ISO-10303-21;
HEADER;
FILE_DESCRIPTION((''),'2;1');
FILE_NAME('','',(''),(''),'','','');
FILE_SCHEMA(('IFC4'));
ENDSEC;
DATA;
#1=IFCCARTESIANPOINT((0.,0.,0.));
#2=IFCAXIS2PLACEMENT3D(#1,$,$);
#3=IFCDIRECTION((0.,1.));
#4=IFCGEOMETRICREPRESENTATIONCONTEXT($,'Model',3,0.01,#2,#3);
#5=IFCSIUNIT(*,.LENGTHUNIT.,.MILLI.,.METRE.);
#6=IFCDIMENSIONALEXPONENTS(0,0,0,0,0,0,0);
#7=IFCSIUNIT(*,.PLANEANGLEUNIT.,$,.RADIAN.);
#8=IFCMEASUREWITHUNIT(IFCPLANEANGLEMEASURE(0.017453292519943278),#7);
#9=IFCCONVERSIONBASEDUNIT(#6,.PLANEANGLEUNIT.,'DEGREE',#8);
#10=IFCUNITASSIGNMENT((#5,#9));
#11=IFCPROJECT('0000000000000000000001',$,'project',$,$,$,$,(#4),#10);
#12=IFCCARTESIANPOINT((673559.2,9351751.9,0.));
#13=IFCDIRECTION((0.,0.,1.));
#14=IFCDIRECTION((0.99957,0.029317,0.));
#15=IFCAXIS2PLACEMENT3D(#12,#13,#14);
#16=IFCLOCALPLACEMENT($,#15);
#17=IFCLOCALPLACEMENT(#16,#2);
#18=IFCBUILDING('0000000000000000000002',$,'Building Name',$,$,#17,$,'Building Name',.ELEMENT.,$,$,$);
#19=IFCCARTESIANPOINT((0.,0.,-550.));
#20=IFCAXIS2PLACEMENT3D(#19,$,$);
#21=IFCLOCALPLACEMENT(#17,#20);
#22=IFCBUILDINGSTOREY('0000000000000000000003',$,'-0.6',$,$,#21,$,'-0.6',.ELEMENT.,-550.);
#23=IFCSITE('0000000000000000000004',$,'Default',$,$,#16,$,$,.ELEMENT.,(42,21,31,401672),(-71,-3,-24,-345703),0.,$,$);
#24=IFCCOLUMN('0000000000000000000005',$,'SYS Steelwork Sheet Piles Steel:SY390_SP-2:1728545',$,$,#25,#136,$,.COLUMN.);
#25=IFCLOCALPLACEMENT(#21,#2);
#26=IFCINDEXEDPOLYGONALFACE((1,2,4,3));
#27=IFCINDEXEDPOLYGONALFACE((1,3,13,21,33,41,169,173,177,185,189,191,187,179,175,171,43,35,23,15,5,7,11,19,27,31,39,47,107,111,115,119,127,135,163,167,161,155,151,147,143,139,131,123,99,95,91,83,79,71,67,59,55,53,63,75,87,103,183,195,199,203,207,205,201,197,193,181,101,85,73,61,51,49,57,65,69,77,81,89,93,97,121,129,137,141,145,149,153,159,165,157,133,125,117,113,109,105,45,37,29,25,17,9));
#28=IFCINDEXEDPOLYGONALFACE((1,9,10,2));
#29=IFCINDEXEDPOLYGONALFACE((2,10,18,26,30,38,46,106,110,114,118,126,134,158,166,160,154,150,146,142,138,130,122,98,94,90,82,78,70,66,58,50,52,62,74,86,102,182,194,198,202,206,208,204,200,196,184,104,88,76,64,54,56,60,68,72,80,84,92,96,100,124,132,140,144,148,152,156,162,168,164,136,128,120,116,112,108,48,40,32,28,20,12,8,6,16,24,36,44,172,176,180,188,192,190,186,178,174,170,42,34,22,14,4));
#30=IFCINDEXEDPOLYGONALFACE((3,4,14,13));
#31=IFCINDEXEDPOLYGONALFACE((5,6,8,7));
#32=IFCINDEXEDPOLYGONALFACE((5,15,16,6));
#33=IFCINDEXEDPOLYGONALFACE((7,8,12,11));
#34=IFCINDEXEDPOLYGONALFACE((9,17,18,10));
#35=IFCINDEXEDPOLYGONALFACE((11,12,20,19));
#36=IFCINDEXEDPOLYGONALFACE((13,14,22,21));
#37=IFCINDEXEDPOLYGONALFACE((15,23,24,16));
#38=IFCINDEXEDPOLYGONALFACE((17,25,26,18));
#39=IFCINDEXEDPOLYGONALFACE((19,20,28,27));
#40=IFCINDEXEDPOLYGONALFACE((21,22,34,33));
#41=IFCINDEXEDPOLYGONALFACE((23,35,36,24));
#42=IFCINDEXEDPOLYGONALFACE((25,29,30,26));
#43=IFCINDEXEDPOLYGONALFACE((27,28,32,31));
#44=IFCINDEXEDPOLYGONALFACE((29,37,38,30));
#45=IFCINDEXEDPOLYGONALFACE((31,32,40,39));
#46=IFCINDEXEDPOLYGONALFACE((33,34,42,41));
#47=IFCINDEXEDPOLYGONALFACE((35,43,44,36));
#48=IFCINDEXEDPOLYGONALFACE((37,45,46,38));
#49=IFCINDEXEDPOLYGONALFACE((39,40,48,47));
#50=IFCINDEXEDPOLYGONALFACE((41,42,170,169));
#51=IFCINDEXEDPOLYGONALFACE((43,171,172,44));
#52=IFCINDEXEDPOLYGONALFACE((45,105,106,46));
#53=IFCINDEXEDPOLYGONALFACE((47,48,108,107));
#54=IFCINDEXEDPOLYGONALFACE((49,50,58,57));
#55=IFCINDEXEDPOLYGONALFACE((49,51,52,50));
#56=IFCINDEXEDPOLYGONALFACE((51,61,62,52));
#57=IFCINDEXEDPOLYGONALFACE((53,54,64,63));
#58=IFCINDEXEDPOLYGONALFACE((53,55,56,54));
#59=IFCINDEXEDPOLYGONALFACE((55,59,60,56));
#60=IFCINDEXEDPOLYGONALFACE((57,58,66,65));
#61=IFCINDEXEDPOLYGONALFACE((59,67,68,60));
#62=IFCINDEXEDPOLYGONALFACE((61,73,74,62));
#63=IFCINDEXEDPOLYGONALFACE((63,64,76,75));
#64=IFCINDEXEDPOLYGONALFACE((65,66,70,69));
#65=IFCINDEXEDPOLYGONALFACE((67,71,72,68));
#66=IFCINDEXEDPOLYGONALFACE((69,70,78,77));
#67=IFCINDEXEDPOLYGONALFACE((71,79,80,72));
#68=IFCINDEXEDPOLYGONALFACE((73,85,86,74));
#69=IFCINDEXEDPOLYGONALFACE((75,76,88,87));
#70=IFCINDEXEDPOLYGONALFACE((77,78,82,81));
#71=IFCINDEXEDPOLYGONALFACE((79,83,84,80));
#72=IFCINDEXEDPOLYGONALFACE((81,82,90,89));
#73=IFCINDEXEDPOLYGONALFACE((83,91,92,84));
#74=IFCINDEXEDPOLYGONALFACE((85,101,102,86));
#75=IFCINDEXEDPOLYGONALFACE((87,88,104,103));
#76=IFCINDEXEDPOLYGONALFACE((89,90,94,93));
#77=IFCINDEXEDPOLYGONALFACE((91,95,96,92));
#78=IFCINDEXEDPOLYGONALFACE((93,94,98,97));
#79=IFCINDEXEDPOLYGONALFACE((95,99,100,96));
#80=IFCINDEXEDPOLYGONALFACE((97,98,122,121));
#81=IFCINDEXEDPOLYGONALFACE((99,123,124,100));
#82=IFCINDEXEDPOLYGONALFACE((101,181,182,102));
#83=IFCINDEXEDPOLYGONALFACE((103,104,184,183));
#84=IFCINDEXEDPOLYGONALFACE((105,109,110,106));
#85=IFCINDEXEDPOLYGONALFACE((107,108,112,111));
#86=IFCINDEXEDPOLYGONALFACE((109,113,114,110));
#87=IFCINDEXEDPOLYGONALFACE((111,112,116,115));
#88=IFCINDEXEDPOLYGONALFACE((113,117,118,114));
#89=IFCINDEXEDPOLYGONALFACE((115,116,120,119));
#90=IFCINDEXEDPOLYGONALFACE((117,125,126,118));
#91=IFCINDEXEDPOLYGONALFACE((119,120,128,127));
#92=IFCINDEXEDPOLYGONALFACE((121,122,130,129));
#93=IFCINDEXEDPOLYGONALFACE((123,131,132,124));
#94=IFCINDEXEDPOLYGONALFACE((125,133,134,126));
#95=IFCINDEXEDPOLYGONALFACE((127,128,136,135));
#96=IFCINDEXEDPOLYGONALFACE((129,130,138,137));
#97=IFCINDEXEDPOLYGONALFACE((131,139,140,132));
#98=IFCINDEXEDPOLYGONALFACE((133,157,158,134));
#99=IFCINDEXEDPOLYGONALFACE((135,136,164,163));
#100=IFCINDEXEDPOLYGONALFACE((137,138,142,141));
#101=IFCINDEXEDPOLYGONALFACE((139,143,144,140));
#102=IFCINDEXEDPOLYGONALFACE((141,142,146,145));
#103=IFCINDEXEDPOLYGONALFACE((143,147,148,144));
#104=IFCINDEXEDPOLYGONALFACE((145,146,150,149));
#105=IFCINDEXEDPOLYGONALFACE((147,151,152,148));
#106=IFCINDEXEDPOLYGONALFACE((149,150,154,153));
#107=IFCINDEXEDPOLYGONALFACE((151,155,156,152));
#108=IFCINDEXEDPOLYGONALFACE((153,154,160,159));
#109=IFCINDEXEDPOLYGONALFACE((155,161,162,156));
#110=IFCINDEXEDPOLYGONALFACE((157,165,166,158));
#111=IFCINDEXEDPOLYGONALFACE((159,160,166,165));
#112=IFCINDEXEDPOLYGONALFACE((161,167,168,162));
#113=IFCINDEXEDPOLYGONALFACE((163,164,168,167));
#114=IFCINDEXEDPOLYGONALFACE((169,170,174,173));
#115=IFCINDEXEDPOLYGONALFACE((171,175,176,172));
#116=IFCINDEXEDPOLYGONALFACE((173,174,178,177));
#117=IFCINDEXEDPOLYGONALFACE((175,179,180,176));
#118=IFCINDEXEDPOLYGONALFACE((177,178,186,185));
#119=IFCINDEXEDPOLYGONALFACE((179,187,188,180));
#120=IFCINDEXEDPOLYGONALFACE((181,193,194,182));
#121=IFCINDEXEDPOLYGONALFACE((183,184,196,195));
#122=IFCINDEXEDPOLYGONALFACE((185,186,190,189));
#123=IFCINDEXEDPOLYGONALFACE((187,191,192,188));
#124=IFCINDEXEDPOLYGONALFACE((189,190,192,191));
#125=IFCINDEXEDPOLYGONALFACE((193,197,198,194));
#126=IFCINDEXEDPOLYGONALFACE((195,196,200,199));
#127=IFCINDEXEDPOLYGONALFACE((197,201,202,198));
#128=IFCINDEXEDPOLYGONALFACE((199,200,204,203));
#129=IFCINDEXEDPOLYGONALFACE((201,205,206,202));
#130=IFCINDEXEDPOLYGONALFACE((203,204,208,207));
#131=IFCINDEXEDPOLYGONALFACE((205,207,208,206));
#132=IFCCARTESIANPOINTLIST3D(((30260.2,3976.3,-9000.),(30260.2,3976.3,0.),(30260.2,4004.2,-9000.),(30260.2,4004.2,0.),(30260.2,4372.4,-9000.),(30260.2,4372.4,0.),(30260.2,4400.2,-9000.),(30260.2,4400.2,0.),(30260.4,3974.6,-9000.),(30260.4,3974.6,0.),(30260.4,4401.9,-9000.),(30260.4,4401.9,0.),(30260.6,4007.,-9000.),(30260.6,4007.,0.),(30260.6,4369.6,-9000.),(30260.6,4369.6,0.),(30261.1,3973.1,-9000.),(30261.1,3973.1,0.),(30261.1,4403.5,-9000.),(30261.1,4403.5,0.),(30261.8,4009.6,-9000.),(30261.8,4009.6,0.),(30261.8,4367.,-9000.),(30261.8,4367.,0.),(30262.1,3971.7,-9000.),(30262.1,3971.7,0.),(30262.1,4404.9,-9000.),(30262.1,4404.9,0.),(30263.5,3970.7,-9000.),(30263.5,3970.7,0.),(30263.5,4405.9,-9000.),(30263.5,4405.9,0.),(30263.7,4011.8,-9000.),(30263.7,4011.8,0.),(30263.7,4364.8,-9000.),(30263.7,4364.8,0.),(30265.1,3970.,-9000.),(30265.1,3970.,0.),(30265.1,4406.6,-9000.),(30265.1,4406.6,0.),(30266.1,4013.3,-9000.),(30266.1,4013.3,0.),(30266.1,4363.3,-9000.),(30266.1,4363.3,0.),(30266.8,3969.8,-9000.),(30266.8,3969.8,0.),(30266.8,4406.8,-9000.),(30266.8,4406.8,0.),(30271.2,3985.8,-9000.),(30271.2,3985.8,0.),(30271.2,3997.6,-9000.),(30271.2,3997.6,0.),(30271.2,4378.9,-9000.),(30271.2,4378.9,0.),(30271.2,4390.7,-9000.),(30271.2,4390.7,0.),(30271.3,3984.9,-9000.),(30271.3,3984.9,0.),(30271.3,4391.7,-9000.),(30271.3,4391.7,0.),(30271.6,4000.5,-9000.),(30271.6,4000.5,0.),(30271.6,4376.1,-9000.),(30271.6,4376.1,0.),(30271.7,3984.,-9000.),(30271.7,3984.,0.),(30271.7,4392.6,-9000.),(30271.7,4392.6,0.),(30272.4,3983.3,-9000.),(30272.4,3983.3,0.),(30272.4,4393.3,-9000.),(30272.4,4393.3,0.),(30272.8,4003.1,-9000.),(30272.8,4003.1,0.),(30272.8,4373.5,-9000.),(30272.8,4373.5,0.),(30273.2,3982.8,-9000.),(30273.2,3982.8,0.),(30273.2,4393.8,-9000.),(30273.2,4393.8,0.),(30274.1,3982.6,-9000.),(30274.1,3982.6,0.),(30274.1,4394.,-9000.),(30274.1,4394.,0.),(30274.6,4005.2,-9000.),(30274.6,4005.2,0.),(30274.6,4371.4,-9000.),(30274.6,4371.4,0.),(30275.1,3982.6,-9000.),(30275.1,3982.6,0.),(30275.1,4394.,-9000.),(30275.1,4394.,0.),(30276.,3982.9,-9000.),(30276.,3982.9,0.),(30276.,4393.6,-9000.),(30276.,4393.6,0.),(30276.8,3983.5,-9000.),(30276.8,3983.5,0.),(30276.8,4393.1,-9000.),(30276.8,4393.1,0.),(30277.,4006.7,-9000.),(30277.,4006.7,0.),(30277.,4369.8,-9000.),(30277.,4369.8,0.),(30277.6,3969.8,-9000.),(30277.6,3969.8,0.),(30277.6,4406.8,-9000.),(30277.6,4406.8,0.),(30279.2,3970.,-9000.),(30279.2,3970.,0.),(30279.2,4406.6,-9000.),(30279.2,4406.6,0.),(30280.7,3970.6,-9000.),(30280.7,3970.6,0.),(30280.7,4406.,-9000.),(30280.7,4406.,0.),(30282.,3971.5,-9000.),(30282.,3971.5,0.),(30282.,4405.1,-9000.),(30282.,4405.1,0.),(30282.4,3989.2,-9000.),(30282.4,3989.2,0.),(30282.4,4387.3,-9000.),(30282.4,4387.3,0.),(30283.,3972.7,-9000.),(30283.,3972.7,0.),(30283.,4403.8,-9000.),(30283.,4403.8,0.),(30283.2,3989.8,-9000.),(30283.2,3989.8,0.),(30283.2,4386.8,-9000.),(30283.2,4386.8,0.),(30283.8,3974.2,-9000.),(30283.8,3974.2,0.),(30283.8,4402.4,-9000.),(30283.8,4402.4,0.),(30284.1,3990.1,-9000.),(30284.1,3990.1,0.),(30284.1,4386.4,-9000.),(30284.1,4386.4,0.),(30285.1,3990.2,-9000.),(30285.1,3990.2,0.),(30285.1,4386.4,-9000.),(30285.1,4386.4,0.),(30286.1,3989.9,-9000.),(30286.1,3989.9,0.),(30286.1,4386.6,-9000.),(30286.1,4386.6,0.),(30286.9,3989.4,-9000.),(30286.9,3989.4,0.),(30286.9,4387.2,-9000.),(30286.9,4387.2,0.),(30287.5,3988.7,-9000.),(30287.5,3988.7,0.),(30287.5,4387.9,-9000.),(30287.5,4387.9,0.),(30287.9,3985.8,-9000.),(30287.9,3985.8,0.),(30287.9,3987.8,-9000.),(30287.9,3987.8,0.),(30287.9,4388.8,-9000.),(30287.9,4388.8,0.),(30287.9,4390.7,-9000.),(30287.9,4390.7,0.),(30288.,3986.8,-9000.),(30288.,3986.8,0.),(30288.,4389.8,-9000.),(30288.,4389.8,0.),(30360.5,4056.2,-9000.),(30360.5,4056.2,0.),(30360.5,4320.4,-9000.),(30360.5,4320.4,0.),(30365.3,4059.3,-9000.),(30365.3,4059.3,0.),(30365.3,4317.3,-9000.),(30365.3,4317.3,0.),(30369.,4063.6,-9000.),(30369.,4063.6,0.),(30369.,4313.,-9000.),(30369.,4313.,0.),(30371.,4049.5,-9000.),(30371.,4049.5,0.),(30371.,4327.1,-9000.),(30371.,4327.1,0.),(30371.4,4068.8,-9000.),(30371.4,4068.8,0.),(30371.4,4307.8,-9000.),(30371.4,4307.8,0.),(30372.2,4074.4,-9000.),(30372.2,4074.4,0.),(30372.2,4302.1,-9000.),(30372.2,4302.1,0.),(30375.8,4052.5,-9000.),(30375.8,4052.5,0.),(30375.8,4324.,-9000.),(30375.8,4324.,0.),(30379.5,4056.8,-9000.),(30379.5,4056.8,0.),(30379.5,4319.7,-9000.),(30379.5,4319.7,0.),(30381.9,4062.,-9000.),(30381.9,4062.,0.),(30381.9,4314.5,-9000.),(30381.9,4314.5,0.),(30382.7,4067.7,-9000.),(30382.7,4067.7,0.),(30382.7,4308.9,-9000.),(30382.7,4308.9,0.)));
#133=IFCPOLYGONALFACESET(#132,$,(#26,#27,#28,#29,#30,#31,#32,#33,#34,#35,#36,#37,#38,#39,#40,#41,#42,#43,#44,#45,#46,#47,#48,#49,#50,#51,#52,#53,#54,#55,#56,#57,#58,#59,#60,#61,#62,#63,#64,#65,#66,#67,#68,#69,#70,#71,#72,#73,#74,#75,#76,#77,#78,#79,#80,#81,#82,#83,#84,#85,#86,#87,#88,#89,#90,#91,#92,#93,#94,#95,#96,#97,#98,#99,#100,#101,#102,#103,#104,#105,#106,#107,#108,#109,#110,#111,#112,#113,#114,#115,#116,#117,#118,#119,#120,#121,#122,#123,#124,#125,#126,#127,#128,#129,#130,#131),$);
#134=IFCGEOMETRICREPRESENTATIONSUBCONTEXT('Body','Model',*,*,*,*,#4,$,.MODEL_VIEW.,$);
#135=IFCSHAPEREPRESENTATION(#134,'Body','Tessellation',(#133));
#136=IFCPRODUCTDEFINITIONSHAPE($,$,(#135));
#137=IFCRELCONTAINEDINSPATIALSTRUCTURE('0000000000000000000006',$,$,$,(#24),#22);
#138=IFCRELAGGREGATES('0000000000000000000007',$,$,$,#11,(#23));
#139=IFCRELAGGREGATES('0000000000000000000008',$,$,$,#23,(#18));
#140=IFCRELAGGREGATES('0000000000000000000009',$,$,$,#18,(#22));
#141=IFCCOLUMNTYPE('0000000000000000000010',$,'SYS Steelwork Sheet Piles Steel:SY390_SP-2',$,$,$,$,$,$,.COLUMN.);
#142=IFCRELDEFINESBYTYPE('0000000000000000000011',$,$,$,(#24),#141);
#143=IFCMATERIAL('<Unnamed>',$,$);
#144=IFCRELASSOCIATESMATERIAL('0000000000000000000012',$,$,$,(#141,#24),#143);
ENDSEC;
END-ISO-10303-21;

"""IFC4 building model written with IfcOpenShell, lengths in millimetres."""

from ifc_helpers import new_model, entity, si_unit, converted_unit, direction, frame, origin, place, context, subcontext, project, spatial, line, arc, indexed_curve, outline, extrude, source, transform, mapped, material, type_object, type_shapes, element, save


model = new_model("IFC4")

# Units and contexts
model_context = context("Model", 3, precision=0.01, world=origin(), true_north=direction((0.0, 1.0)))
body_context = subcontext(model_context, "Body", "Model", "MODEL_VIEW")
ifc_project = project(units=[si_unit("LENGTHUNIT", "METRE", prefix="MILLI"), converted_unit("PLANEANGLEUNIT", "DEGREE", entity("IfcPlaneAngleMeasure", 0.017453292519943278), si_unit("PLANEANGLEUNIT", "RADIAN"), dimensions=[0, 0, 0, 0, 0, 0, 0])], contexts=[model_context])

# Site, building, storey
site_placement = place(None, frame((673559.2, 9351751.9, 0.0), z_axis=(0.0, 0.0, 1.0), x_axis=(0.99957, 0.029317, 0.0)))
site = spatial("IfcSite", under=ifc_project, at=site_placement, Name="Default", CompositionType="ELEMENT", RefLatitude=(42, 21, 31, 401672), RefLongitude=(-71, -3, -24, -345703), RefElevation=0.0)
building_placement = place(site_placement, origin())
building = spatial("IfcBuilding", under=site, at=building_placement, Name="Building Name", LongName="Building Name", CompositionType="ELEMENT")
storey_placement = place(building_placement, frame((0.0, 0.0, -550.0)))
storey = spatial("IfcBuildingStorey", under=building, at=storey_placement, Name="-0.6", LongName="-0.6", CompositionType="ELEMENT", Elevation=-550.0)

# Column
ifc_material_1 = material(Name="<Unnamed>")
column_type = type_object("IfcColumnType", Name="SYS Steelwork Sheet Piles Steel:SY390_SP-2", PredefinedType="COLUMN", material=ifc_material_1)
shared_shape_1 = source(origin(), body_context, "Body", "SweptSolid", [
    extrude(outline(indexed_curve([(-120.6, 84.7), (-131.4, 81.6), (-138.8, 73.0), (-181.5, -20.9), (-185.2, -25.2), (-190.6, -26.8), (-202.5, -26.8), (-205.5, -24.8), (-204.8, -21.2), (-199.1, -15.5), (-198.6, -11.5), (-202.5, -10.1), (-214.1, -14.2), (-217.3, -16.6), (-218.5, -20.4), (-218.5, -31.2), (-216.6, -35.8), (-211.9, -37.8), (-184.1, -37.8), (-178.7, -36.2), (-175.0, -31.9), (-132.1, 62.5), (-124.7, 71.1), (-113.9, 74.2), (113.9, 74.2), (124.7, 71.1), (132.1, 62.5), (175.0, -31.9), (178.7, -36.2), (184.1, -37.8), (211.9, -37.8), (216.6, -35.8), (218.5, -31.2), (218.5, -20.4), (217.3, -16.6), (214.1, -14.2), (202.5, -10.1), (198.6, -11.5), (199.1, -15.5), (204.8, -21.2), (205.5, -24.8), (202.5, -26.8), (190.6, -26.8), (185.2, -25.2), (181.5, -20.9), (138.8, 73.0), (131.4, 81.6), (120.6, 84.7)], segments=[arc(1, 2, 3), line(3, 4), arc(4, 5, 6), line(6, 7), arc(7, 8, 9), line(9, 10), arc(10, 11, 12), line(12, 13), arc(13, 14, 15), line(15, 16), arc(16, 17, 18), line(18, 19), arc(19, 20, 21), line(21, 22), arc(22, 23, 24), line(24, 25), arc(25, 26, 27), line(27, 28), arc(28, 29, 30), line(30, 31), arc(31, 32, 33), line(33, 34), arc(34, 35, 36), line(36, 37), arc(37, 38, 39), line(39, 40), arc(40, 41, 42), line(42, 43), arc(43, 44, 45), line(45, 46), arc(46, 47, 48), line(48, 1)], self_intersect=False)), frame((0.0, 15.3, -9550.0)), (0.0, 0.0, 1.0), 9000.0),
])
type_shapes(column_type, [shared_shape_1])
for number, where, z_axis, x_axis, name in (
    (1, (30282.7, 4188.3, 550.0), (0.0, 0.0, 1.0), (0.0, -1.0, 0.0), "SYS Steelwork Sheet Piles Steel:SY390_SP-2:1728545"),
):
    element("IfcColumn", number, at=place(storey_placement, frame(where, z_axis=z_axis, x_axis=x_axis)), inside=storey, type_object=column_type, material=ifc_material_1, Name=name, PredefinedType="COLUMN", context=body_context, shape_type="MappedRepresentation", body=[
        mapped(shared_shape_1, transform((0.0, 0.0, 0.0), scale=1.0)),
    ])

save(model, "model.ifc")
